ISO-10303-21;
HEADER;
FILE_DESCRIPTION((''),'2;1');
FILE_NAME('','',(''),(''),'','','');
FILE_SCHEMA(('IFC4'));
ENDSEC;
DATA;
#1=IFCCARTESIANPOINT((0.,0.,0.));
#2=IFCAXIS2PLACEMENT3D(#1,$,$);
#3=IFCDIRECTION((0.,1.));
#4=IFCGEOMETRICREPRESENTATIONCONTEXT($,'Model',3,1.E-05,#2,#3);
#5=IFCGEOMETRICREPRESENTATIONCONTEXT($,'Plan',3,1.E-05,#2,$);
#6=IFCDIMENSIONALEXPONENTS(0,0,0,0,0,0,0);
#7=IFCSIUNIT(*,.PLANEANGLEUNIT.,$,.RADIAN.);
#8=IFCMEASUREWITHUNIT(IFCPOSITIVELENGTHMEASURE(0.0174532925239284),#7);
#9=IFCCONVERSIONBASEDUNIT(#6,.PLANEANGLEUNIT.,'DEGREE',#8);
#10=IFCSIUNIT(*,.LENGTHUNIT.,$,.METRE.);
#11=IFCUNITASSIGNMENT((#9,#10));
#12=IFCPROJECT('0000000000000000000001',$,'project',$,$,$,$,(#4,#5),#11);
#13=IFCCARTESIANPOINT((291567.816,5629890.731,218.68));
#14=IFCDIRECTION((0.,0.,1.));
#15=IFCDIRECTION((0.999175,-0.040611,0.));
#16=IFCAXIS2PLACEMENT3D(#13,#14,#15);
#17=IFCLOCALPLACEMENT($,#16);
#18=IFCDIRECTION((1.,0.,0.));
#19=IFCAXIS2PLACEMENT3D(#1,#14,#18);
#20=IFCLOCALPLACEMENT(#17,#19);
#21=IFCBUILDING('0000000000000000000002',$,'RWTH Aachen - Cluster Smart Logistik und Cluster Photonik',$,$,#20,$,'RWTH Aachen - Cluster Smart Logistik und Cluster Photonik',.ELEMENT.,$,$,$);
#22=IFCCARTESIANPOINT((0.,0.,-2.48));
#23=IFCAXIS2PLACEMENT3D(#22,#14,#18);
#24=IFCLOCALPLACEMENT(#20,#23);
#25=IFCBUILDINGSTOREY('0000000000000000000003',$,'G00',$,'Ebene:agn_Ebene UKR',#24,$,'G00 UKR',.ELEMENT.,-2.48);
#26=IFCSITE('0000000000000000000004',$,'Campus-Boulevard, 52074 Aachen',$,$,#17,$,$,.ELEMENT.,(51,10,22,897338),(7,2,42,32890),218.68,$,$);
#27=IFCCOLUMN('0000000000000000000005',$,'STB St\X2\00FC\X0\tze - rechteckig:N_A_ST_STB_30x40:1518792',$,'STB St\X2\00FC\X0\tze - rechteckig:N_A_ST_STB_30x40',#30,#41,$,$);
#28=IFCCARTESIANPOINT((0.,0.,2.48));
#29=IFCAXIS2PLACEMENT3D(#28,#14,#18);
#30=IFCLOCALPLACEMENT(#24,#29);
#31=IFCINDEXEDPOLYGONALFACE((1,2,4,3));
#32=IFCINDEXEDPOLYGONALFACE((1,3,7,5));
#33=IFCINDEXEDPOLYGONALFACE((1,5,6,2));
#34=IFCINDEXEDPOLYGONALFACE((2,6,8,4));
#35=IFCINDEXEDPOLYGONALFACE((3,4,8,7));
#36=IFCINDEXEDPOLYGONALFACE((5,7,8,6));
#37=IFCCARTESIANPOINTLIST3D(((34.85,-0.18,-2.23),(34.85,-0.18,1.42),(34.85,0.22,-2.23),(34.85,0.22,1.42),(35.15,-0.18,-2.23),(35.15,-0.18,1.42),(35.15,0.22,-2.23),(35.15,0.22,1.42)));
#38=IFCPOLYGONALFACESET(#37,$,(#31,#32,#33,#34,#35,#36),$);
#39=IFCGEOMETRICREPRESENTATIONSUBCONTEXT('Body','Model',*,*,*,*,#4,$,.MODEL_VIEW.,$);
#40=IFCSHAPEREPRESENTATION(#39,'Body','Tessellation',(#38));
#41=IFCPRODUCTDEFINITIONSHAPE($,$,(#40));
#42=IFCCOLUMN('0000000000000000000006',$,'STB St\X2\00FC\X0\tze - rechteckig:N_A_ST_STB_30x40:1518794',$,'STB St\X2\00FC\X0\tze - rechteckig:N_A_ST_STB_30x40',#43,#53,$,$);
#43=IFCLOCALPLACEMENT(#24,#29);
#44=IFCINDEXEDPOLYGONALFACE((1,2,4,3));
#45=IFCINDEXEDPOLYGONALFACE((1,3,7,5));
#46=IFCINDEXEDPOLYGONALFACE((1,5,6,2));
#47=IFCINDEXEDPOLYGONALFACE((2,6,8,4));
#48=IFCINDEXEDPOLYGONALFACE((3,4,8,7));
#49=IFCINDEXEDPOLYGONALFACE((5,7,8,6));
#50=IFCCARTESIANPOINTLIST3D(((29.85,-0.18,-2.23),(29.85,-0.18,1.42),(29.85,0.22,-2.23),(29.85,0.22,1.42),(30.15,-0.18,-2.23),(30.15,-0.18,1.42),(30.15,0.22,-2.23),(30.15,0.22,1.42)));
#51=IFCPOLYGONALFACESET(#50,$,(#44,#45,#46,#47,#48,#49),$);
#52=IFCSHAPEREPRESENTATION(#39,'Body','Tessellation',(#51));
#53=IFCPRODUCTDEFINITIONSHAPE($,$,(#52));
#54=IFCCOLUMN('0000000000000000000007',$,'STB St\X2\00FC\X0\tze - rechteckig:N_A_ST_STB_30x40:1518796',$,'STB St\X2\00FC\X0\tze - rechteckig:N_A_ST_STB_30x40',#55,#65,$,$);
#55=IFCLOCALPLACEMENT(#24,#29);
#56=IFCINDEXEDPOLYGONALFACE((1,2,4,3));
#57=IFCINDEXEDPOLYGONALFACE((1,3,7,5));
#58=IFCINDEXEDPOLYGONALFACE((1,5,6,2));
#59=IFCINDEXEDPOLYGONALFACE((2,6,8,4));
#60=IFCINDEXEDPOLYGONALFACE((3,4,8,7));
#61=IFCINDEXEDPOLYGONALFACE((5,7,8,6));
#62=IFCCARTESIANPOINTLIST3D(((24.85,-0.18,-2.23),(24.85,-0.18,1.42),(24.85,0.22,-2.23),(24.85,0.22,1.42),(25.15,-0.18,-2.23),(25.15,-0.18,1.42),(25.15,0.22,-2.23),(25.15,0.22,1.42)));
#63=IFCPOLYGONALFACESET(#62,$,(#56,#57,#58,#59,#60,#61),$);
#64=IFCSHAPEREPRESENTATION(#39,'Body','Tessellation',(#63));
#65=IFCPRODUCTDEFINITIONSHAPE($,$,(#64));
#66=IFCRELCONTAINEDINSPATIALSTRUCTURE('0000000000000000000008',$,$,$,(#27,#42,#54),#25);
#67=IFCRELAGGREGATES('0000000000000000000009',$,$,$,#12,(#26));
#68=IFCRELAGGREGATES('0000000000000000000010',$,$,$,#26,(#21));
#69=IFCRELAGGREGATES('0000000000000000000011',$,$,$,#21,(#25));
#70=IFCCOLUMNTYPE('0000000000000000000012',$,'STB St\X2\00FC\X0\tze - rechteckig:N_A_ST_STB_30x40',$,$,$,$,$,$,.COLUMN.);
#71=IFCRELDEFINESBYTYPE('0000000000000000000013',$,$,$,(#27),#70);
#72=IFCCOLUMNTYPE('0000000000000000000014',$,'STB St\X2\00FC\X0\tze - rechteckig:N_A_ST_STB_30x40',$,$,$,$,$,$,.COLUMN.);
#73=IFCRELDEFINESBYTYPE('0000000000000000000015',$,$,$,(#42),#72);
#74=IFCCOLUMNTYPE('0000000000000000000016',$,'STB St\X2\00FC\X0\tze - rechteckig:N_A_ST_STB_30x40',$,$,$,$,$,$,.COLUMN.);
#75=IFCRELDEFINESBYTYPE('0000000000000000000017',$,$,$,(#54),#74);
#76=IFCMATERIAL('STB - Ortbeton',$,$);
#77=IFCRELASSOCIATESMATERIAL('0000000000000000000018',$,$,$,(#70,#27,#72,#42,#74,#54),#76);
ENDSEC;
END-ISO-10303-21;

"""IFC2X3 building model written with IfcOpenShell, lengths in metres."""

from ifc_helpers import new_model, entity, si_unit, converted_unit, direction, frame, origin, origin_with_axes, origin_2d_with_axis, place, context, subcontext, project, spatial, rectangle, extrude, source, transform, mapped, material, type_object, element, save


model = new_model("IFC2X3")

# Units and contexts
model_context = context("Model", 3, precision=1e-05, world=origin(), true_north=direction((0.0, 1.0)))
plan_context = context("Plan", 3, precision=1e-05, world=origin())
body_context = subcontext(model_context, "Body", "Model", "MODEL_VIEW")
ifc_project = project(units=[converted_unit("PLANEANGLEUNIT", "DEGREE", entity("IfcPositiveLengthMeasure", 0.0174532925239284), si_unit("PLANEANGLEUNIT", "RADIAN"), dimensions=[0, 0, 0, 0, 0, 0, 0]), si_unit("LENGTHUNIT", "METRE")], contexts=[model_context, plan_context])

# Site, building, storey
site_placement = place(None, frame((291567.816, 5629890.731, 218.68), z_axis=(0.0, 0.0, 1.0), x_axis=(0.999175, -0.040611, 0.0)))
site = spatial("IfcSite", under=ifc_project, at=site_placement, Name="Campus-Boulevard, 52074 Aachen", CompositionType="ELEMENT", RefLatitude=(51, 10, 22, 897338), RefLongitude=(7, 2, 42, 32890), RefElevation=218.68)
building_placement = place(site_placement, origin_with_axes())
building = spatial("IfcBuilding", under=site, at=building_placement, Name="RWTH Aachen - Cluster Smart Logistik und Cluster Photonik", LongName="RWTH Aachen - Cluster Smart Logistik und Cluster Photonik", CompositionType="ELEMENT")
storey_placement = place(building_placement, frame((0.0, 0.0, -2.48), z_axis=(0.0, 0.0, 1.0), x_axis=(1.0, 0.0, 0.0)))
storey = spatial("IfcBuildingStorey", under=building, at=storey_placement, Name="G00", ObjectType="Ebene:agn_Ebene UKR", LongName="G00 UKR", CompositionType="ELEMENT", Elevation=-2.48)

# Shared definitions
ifc_material = material(Name="STB - Ortbeton")

# Columns
column_type_1 = type_object("IfcColumnType", Name="STB Stütze - rechteckig:N_A_ST_STB_30x40", PredefinedType="COLUMN", material=ifc_material)
shared_shape_1 = source(origin(), body_context, "Body", "SweptSolid", [
    extrude(rectangle(XDim=0.4, YDim=0.3, at=origin_2d_with_axis()), frame((35.0, 0.02, -2.23), z_axis=(0.0, 0.0, 1.0), x_axis=(0.0, -1.0, 0.0)), (0.0, 0.0, 1.0), 3.65),
])
column_1_placement = place(storey_placement, frame((0.0, 0.0, 2.48), z_axis=(0.0, 0.0, 1.0), x_axis=(1.0, 0.0, 0.0)))
element("IfcColumn", 1, at=column_1_placement, inside=storey, type_object=column_type_1, material=ifc_material, Name="STB Stütze - rechteckig:N_A_ST_STB_30x40:1518792", ObjectType="STB Stütze - rechteckig:N_A_ST_STB_30x40", context=body_context, shape_type="MappedRepresentation", body=[
    mapped(shared_shape_1, transform((0.0, 0.0, 0.0), scale=1.0)),
])
column_type_2 = type_object("IfcColumnType", Name="STB Stütze - rechteckig:N_A_ST_STB_30x40", PredefinedType="COLUMN", material=ifc_material)
shared_shape_2 = source(origin(), body_context, "Body", "SweptSolid", [
    extrude(rectangle(XDim=0.4, YDim=0.3, at=origin_2d_with_axis()), frame((30.0, 0.02, -2.23), z_axis=(0.0, 0.0, 1.0), x_axis=(0.0, -1.0, 0.0)), (0.0, 0.0, 1.0), 3.65),
])
column_2_placement = place(storey_placement, frame((0.0, 0.0, 2.48), z_axis=(0.0, 0.0, 1.0), x_axis=(1.0, 0.0, 0.0)))
element("IfcColumn", 2, at=column_2_placement, inside=storey, type_object=column_type_2, material=ifc_material, Name="STB Stütze - rechteckig:N_A_ST_STB_30x40:1518794", ObjectType="STB Stütze - rechteckig:N_A_ST_STB_30x40", context=body_context, shape_type="MappedRepresentation", body=[
    mapped(shared_shape_2, transform((0.0, 0.0, 0.0), scale=1.0)),
])
column_type_3 = type_object("IfcColumnType", Name="STB Stütze - rechteckig:N_A_ST_STB_30x40", PredefinedType="COLUMN", material=ifc_material)
shared_shape_3 = source(origin(), body_context, "Body", "SweptSolid", [
    extrude(rectangle(XDim=0.4, YDim=0.3, at=origin_2d_with_axis()), frame((25.0, 0.02, -2.23), z_axis=(0.0, 0.0, 1.0), x_axis=(0.0, -1.0, 0.0)), (0.0, 0.0, 1.0), 3.65),
])
column_3_placement = place(storey_placement, frame((0.0, 0.0, 2.48), z_axis=(0.0, 0.0, 1.0), x_axis=(1.0, 0.0, 0.0)))
element("IfcColumn", 3, at=column_3_placement, inside=storey, type_object=column_type_3, material=ifc_material, Name="STB Stütze - rechteckig:N_A_ST_STB_30x40:1518796", ObjectType="STB Stütze - rechteckig:N_A_ST_STB_30x40", context=body_context, shape_type="MappedRepresentation", body=[
    mapped(shared_shape_3, transform((0.0, 0.0, 0.0), scale=1.0)),
])

save(model, "model.ifc")
